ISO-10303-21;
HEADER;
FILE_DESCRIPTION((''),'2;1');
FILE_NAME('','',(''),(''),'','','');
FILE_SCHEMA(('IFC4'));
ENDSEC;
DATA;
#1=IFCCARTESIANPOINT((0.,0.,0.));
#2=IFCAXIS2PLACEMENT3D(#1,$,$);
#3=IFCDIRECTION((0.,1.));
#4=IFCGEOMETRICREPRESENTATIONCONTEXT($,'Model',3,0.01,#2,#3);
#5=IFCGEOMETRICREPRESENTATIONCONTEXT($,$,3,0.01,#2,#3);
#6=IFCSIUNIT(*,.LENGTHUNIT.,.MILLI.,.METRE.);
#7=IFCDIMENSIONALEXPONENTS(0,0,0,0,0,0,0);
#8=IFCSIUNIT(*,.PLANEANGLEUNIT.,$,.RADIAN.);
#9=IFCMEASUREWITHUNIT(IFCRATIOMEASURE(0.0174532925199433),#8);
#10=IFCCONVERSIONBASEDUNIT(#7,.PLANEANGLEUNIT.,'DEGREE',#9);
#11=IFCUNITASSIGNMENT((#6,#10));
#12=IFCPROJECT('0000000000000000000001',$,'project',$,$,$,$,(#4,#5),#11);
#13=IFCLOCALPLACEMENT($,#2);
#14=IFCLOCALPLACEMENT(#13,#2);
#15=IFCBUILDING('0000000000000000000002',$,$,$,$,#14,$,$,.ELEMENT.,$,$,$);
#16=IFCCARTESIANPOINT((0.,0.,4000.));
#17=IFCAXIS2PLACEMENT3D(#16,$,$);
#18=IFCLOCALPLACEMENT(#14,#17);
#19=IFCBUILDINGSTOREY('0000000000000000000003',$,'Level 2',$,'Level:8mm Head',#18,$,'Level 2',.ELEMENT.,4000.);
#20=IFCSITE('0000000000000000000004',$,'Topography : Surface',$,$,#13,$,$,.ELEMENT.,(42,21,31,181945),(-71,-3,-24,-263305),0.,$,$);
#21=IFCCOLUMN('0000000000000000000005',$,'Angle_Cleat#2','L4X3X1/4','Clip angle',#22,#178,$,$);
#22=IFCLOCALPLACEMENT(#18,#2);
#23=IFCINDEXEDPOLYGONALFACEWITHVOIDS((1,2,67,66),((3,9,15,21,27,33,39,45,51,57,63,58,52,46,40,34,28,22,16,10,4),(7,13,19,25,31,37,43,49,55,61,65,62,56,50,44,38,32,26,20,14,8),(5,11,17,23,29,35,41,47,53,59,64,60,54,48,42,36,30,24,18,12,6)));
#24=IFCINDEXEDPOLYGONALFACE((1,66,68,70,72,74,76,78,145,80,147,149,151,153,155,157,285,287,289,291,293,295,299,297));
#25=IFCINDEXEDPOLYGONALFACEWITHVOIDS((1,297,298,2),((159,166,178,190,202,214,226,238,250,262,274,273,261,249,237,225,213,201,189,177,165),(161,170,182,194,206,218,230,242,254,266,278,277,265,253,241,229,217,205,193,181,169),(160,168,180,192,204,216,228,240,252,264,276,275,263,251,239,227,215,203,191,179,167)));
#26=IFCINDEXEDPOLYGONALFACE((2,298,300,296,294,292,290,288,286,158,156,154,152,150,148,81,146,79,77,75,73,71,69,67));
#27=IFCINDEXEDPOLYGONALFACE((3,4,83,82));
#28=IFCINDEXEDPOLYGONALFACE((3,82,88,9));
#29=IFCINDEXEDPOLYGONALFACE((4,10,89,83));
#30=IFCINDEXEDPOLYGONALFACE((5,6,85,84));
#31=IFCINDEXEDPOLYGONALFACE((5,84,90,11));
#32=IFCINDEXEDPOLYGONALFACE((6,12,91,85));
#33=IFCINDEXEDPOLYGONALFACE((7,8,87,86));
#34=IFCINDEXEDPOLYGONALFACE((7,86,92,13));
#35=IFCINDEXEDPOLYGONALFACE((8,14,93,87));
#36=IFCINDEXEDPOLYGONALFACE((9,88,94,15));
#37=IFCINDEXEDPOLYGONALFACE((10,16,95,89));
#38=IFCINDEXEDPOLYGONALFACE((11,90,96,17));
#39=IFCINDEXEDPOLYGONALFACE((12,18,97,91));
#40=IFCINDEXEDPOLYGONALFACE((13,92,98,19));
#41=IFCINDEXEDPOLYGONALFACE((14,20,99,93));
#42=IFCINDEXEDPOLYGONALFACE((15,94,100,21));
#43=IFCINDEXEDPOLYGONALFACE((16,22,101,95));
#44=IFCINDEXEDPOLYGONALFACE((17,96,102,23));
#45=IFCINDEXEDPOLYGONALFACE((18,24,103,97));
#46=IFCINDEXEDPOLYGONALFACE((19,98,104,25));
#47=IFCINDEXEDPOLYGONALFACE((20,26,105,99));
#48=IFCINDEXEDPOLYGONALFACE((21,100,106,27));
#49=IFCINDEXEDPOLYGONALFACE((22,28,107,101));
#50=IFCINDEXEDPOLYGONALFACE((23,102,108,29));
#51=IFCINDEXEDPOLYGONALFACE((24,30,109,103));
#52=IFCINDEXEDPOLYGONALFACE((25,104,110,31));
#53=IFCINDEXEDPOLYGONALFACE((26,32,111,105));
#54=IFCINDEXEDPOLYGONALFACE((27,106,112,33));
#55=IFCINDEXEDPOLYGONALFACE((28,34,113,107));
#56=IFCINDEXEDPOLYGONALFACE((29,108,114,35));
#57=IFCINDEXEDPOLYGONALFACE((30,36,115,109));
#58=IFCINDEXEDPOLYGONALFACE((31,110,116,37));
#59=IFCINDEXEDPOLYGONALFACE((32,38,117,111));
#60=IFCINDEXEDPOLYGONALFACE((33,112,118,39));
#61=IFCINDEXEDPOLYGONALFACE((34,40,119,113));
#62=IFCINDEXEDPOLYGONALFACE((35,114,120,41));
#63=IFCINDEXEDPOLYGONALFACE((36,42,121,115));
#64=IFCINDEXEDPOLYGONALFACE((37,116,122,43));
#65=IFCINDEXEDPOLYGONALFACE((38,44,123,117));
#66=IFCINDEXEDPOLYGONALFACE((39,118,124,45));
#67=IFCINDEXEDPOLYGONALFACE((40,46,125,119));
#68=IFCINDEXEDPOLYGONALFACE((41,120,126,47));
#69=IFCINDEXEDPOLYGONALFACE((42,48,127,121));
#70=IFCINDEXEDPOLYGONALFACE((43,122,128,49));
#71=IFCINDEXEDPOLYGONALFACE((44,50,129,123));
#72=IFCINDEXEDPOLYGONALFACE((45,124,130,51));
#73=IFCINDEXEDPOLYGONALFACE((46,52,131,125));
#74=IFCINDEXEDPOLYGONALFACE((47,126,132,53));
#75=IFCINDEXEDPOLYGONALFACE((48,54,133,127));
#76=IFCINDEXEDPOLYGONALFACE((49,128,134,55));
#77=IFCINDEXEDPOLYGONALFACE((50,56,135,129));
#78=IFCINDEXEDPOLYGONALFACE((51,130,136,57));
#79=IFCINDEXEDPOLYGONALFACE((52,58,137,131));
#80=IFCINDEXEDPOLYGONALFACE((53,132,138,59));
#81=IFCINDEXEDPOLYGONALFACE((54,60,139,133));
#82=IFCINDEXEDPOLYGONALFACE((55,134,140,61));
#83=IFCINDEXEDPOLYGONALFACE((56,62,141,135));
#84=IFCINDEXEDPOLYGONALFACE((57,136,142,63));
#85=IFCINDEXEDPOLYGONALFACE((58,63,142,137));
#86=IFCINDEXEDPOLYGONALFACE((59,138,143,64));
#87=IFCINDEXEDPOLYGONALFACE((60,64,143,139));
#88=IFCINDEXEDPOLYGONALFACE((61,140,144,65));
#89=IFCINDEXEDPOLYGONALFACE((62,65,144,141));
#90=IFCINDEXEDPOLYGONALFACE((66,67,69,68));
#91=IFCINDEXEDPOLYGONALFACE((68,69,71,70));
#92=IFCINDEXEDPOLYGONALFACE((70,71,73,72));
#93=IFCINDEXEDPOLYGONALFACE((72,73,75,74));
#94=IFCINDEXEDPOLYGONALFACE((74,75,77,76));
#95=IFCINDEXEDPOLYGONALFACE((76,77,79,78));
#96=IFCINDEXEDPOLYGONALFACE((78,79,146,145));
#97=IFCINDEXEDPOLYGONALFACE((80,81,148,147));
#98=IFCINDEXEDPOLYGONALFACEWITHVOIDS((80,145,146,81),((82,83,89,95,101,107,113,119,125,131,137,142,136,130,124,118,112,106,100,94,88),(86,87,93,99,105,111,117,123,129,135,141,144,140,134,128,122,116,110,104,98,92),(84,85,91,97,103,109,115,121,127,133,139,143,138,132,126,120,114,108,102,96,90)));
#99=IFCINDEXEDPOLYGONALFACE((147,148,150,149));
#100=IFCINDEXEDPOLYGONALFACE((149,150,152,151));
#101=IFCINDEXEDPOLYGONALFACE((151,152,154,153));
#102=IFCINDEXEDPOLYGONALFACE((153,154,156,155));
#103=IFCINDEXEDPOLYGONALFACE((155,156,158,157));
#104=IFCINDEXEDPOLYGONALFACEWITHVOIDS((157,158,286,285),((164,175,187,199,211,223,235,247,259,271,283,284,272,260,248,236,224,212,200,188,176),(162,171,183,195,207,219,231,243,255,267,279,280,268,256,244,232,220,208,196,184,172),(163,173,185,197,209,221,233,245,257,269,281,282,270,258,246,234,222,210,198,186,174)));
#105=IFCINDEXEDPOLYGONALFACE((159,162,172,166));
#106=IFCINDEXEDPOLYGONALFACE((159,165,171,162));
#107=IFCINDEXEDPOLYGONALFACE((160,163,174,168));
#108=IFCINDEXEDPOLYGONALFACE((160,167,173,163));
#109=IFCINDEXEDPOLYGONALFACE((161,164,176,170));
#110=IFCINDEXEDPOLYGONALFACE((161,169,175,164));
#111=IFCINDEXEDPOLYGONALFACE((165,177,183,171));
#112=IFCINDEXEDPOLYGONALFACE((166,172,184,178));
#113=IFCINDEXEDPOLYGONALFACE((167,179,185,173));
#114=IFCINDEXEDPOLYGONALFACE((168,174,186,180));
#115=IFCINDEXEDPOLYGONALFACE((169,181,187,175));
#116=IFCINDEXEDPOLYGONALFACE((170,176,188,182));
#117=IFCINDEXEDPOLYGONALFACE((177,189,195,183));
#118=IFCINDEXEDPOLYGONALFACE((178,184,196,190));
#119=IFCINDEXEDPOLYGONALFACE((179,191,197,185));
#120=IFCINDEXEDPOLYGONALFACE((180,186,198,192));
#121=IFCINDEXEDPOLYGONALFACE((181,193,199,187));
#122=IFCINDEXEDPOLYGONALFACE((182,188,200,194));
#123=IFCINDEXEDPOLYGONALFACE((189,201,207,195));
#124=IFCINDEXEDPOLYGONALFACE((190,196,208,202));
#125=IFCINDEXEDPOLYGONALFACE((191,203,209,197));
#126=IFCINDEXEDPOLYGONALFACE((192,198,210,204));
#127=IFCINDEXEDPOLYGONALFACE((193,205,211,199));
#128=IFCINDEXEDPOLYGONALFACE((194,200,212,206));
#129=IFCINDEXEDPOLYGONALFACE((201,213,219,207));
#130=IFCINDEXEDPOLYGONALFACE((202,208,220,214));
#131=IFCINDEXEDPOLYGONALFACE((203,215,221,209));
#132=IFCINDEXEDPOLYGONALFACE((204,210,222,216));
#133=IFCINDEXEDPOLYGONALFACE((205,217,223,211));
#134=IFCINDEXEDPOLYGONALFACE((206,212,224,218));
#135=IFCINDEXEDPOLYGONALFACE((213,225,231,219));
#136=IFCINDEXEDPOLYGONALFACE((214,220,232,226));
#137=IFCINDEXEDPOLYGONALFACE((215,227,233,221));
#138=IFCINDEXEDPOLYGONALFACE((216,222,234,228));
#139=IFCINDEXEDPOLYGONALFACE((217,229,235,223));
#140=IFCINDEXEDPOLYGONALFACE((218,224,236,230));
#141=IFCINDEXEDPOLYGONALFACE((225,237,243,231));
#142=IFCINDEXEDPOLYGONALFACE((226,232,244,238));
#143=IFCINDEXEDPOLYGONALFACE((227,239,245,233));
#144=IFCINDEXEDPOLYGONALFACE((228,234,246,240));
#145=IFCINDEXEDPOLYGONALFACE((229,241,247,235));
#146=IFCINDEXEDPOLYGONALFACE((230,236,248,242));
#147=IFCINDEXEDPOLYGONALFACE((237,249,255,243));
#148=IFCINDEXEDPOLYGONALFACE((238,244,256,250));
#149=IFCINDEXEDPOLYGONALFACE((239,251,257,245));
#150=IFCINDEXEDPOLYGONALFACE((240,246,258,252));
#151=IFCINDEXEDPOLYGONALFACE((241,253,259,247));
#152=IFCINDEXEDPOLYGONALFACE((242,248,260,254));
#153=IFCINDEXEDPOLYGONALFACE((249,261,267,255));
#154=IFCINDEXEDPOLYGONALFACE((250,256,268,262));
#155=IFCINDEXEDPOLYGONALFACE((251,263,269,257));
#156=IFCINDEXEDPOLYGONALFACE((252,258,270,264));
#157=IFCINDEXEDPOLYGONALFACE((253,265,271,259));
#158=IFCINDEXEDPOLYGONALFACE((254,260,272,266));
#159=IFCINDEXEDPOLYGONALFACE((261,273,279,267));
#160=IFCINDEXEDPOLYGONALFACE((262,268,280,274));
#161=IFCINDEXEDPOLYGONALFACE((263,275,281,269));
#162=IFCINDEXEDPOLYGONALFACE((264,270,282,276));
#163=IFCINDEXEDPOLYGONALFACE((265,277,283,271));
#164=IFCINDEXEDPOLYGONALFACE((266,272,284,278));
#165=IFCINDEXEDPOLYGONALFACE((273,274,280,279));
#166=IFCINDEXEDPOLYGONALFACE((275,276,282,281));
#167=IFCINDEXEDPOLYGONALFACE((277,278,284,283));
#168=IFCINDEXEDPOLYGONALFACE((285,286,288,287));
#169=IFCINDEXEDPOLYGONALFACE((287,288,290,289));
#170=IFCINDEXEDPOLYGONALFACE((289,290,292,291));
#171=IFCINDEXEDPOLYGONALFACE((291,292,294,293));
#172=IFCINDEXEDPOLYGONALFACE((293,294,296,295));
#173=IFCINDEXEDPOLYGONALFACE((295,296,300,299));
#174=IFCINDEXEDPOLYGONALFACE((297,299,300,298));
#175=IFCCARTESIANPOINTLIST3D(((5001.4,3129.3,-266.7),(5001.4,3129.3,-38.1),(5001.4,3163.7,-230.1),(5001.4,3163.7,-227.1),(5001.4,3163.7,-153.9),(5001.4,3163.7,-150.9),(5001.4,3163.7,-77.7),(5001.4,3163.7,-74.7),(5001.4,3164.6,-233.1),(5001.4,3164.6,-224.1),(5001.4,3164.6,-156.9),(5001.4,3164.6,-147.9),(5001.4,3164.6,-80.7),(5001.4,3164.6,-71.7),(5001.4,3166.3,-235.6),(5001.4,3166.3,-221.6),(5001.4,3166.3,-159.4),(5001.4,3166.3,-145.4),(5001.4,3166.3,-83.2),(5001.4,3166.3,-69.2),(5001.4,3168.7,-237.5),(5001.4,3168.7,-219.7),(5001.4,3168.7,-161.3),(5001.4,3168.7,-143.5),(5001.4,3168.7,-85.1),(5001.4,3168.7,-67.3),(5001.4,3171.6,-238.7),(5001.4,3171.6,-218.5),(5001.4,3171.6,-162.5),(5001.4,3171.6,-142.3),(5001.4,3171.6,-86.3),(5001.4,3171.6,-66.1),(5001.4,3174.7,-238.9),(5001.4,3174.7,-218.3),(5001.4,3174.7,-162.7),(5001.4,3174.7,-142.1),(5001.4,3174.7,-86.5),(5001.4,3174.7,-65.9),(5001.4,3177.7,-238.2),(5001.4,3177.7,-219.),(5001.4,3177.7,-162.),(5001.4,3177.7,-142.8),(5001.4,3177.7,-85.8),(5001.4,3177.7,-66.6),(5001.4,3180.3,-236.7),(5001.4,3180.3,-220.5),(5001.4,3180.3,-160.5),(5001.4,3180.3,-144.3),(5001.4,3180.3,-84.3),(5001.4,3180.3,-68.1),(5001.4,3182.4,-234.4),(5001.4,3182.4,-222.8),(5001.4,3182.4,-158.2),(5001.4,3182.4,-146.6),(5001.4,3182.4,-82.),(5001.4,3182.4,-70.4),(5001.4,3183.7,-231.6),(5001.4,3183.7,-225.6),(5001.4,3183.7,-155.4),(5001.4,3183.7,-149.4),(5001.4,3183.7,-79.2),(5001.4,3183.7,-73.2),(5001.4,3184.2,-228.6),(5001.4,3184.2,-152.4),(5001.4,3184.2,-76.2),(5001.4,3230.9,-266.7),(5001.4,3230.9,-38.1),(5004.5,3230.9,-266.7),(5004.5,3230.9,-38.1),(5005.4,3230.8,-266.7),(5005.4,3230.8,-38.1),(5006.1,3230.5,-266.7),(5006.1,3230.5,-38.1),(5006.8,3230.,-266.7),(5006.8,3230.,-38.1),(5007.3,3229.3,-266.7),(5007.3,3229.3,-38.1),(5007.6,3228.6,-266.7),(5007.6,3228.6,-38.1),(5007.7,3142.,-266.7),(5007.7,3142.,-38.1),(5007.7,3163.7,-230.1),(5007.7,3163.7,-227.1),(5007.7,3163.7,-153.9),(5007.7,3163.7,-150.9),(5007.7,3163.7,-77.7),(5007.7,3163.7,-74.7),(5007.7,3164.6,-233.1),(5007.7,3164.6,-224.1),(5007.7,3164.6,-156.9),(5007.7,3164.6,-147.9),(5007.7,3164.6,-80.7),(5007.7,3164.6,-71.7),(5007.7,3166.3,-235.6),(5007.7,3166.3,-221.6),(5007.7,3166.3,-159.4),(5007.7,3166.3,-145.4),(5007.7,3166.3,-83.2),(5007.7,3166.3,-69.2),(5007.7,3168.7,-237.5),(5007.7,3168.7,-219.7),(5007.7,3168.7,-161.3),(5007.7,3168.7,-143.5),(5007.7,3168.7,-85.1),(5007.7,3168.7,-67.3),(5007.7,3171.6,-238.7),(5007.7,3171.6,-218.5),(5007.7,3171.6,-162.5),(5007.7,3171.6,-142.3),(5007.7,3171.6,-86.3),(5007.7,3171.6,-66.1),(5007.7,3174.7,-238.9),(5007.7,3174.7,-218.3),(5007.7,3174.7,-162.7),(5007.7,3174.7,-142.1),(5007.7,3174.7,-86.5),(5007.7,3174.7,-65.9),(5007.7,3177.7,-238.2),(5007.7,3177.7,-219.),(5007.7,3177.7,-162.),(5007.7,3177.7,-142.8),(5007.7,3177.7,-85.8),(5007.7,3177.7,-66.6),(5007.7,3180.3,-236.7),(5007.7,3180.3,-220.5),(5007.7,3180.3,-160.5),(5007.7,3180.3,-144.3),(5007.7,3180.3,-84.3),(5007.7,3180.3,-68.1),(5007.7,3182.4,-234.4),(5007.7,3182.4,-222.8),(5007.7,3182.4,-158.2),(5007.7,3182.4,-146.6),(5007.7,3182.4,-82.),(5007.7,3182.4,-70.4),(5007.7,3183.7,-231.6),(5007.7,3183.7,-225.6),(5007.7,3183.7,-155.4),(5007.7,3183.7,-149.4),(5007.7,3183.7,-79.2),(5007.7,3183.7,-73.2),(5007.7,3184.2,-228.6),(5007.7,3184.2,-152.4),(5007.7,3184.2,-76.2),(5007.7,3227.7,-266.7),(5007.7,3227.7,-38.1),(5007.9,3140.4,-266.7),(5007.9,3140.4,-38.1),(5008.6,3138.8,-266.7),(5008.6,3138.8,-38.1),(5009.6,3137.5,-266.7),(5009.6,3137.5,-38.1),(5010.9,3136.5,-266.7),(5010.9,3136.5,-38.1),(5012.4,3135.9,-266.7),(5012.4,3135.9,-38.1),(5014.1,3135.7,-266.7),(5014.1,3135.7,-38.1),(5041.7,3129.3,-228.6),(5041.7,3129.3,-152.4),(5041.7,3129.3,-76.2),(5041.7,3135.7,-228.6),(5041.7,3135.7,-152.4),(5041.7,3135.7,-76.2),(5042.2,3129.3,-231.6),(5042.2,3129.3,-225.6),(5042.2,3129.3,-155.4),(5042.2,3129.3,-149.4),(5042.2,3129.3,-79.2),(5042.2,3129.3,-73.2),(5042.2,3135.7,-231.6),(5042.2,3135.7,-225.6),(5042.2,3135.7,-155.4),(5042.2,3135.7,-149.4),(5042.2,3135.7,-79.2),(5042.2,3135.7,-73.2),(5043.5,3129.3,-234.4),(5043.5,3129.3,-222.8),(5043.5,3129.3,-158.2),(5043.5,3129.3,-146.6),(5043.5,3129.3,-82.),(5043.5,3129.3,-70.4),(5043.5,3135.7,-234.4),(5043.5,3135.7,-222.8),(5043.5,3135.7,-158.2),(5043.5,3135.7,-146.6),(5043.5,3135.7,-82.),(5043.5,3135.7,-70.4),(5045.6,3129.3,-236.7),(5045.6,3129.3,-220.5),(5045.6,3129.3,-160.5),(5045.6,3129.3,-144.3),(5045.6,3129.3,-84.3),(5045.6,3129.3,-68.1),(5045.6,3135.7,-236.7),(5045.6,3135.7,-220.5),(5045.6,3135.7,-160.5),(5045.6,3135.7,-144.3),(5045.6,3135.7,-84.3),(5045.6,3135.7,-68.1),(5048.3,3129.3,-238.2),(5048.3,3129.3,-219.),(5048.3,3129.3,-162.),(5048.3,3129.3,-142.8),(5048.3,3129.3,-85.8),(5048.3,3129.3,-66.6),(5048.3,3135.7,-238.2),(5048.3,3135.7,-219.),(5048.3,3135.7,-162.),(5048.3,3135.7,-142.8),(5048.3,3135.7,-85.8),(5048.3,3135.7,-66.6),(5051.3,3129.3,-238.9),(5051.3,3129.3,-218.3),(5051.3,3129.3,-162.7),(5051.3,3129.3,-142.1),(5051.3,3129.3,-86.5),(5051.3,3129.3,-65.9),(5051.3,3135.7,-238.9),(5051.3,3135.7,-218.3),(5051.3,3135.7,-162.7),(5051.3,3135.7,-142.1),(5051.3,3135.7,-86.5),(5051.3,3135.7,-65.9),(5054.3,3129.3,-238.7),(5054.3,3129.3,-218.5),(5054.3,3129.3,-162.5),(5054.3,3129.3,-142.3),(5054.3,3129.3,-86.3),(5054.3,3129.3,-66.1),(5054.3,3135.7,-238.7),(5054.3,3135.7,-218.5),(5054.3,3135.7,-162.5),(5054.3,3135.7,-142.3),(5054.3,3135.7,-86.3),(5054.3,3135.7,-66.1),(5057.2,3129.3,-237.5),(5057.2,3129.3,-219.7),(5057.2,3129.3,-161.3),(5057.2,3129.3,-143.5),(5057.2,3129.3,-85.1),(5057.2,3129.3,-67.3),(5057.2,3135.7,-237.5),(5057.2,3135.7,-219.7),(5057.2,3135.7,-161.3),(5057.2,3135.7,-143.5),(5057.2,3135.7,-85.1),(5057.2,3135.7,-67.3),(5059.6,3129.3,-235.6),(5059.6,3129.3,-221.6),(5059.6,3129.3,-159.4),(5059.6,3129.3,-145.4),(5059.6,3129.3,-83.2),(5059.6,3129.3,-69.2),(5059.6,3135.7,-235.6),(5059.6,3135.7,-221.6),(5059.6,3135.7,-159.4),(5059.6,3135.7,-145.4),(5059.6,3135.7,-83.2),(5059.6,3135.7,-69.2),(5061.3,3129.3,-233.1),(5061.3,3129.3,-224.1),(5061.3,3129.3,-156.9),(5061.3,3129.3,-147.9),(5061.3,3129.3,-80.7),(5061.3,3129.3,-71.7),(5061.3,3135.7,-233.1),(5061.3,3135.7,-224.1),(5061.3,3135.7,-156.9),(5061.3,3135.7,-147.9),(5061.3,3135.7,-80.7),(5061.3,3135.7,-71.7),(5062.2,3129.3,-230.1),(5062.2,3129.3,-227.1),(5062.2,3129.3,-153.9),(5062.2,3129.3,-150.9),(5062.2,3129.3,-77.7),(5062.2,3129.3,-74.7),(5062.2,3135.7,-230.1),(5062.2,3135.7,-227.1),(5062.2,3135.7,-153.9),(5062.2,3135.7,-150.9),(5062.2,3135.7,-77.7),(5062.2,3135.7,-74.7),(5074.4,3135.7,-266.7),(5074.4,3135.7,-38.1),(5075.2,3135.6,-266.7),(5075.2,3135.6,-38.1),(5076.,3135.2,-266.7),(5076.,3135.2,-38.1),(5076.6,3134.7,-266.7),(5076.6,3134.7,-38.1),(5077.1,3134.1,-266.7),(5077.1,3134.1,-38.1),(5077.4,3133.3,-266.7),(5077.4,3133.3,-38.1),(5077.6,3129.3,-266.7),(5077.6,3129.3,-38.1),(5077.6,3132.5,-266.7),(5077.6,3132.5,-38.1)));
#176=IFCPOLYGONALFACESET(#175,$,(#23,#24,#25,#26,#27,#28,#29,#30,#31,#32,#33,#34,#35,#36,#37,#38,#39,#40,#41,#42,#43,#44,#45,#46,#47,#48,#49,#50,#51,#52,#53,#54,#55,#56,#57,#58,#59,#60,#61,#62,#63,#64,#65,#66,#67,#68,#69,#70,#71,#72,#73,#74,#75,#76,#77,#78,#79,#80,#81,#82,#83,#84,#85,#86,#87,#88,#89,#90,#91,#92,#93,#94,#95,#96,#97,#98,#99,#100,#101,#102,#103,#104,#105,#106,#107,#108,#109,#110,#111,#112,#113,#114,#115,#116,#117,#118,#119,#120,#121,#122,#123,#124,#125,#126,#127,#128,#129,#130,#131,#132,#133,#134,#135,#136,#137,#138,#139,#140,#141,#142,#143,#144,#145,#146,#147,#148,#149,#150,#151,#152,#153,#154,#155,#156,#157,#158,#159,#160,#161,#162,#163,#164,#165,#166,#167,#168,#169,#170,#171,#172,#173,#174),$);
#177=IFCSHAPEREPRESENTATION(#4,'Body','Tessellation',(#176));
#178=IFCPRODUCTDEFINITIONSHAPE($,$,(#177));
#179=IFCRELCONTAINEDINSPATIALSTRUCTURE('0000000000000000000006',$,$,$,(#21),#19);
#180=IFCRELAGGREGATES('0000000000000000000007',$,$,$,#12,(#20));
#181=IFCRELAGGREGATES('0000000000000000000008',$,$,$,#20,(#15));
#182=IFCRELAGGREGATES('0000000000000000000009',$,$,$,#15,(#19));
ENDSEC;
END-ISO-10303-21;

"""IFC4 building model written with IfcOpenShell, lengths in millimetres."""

from ifc_helpers import new_model, entity, si_unit, converted_unit, direction, frame, frame_2d, origin, origin_2d_with_axis, place, context, project, spatial, circle, l_section, extrude, element, save


model = new_model("IFC4")

# Units and contexts
model_context = context("Model", 3, precision=0.01, world=origin(), true_north=direction((0.0, 1.0)))
context_of_model = context(None, 3, precision=0.01, world=origin(), true_north=direction((0.0, 1.0)))
ifc_project = project(units=[si_unit("LENGTHUNIT", "METRE", prefix="MILLI"), converted_unit("PLANEANGLEUNIT", "DEGREE", entity("IfcRatioMeasure", 0.0174532925199433), si_unit("PLANEANGLEUNIT", "RADIAN"), dimensions=[0, 0, 0, 0, 0, 0, 0])], contexts=[model_context, context_of_model])

# Site, building, storey
site_placement = place(None, origin())
site = spatial("IfcSite", under=ifc_project, at=site_placement, Name="Topography : Surface", CompositionType="ELEMENT", RefLatitude=(42, 21, 31, 181945), RefLongitude=(-71, -3, -24, -263305), RefElevation=0.0)
building_placement = place(site_placement, origin())
building = spatial("IfcBuilding", under=site, at=building_placement, CompositionType="ELEMENT")
storey_placement = place(building_placement, frame((0.0, 0.0, 4000.0)))
storey = spatial("IfcBuildingStorey", under=building, at=storey_placement, Name="Level 2", ObjectType="Level:8mm Head", LongName="Level 2", CompositionType="ELEMENT", Elevation=4000.0)

# Column, openings
column_1_placement = place(storey_placement, frame((5019.6, 3160.4, -38.1)))
column_1 = element("IfcColumn", 1, at=column_1_placement, inside=storey, Name="Angle_Cleat#2", Description="L4X3X1/4", ObjectType="Clip angle", context=model_context, shape_type="SweptSolid", body=[
    extrude(l_section(Depth=101.6, Width=76.2, Thickness=6.3, FilletRadius=6.3, EdgeRadius=3.2, at=frame_2d((19.8, 19.7))), origin(), (0.0, 0.0, -1.0), 228.6),
])
opening_1_placement = place(column_1_placement, frame((32.4, -31.5, -114.3), z_axis=(0.0, 1.0, 0.0), x_axis=(-1.0, 0.0, 0.0)))
element("IfcOpeningElement", 2, at=opening_1_placement, cuts=column_1, ObjectType="Opening", context=model_context, shape_type="SweptSolid", body=[
    extrude(circle(Radius=10.3, at=origin_2d_with_axis()), origin(), (0.0, 0.0, 1.0), 7.3),
])
opening_2_placement = place(column_1_placement, frame((32.4, -31.5, -114.3), z_axis=(0.0, 1.0, 0.0), x_axis=(-1.0, 0.0, 0.0)))
element("IfcOpeningElement", 3, at=opening_2_placement, cuts=column_1, ObjectType="Opening", context=model_context, shape_type="SweptSolid", body=[
    extrude(circle(Radius=10.3, at=frame_2d((0.0, 76.2), x_axis=(1.0, 0.0))), origin(), (0.0, 0.0, 1.0), 7.3),
])
opening_3_placement = place(column_1_placement, frame((32.4, -31.5, -114.3), z_axis=(0.0, 1.0, 0.0), x_axis=(-1.0, 0.0, 0.0)))
element("IfcOpeningElement", 4, at=opening_3_placement, cuts=column_1, ObjectType="Opening", context=model_context, shape_type="SweptSolid", body=[
    extrude(circle(Radius=10.3, at=frame_2d((0.0, -76.2), x_axis=(1.0, 0.0))), origin(), (0.0, 0.0, 1.0), 7.3),
])
opening_4_placement = place(column_1_placement, frame((-11.6, 13.5, -114.3), z_axis=(-1.0, 0.0, 0.0), x_axis=(0.0, 1.0, 0.0)))
element("IfcOpeningElement", 5, at=opening_4_placement, cuts=column_1, ObjectType="Opening", context=model_context, shape_type="SweptSolid", body=[
    extrude(circle(Radius=10.3, at=origin_2d_with_axis()), origin(), (0.0, 0.0, 1.0), 7.3),
])
opening_5_placement = place(column_1_placement, frame((-11.6, 13.5, -114.3), z_axis=(-1.0, 0.0, 0.0), x_axis=(0.0, 1.0, 0.0)))
element("IfcOpeningElement", 6, at=opening_5_placement, cuts=column_1, ObjectType="Opening", context=model_context, shape_type="SweptSolid", body=[
    extrude(circle(Radius=10.3, at=frame_2d((0.0, 76.2), x_axis=(1.0, 0.0))), origin(), (0.0, 0.0, 1.0), 7.3),
])
opening_6_placement = place(column_1_placement, frame((-11.6, 13.5, -114.3), z_axis=(-1.0, 0.0, 0.0), x_axis=(0.0, 1.0, 0.0)))
element("IfcOpeningElement", 7, at=opening_6_placement, cuts=column_1, ObjectType="Opening", context=model_context, shape_type="SweptSolid", body=[
    extrude(circle(Radius=10.3, at=frame_2d((0.0, -76.2), x_axis=(1.0, 0.0))), origin(), (0.0, 0.0, 1.0), 7.3),
])

save(model, "model.ifc")
